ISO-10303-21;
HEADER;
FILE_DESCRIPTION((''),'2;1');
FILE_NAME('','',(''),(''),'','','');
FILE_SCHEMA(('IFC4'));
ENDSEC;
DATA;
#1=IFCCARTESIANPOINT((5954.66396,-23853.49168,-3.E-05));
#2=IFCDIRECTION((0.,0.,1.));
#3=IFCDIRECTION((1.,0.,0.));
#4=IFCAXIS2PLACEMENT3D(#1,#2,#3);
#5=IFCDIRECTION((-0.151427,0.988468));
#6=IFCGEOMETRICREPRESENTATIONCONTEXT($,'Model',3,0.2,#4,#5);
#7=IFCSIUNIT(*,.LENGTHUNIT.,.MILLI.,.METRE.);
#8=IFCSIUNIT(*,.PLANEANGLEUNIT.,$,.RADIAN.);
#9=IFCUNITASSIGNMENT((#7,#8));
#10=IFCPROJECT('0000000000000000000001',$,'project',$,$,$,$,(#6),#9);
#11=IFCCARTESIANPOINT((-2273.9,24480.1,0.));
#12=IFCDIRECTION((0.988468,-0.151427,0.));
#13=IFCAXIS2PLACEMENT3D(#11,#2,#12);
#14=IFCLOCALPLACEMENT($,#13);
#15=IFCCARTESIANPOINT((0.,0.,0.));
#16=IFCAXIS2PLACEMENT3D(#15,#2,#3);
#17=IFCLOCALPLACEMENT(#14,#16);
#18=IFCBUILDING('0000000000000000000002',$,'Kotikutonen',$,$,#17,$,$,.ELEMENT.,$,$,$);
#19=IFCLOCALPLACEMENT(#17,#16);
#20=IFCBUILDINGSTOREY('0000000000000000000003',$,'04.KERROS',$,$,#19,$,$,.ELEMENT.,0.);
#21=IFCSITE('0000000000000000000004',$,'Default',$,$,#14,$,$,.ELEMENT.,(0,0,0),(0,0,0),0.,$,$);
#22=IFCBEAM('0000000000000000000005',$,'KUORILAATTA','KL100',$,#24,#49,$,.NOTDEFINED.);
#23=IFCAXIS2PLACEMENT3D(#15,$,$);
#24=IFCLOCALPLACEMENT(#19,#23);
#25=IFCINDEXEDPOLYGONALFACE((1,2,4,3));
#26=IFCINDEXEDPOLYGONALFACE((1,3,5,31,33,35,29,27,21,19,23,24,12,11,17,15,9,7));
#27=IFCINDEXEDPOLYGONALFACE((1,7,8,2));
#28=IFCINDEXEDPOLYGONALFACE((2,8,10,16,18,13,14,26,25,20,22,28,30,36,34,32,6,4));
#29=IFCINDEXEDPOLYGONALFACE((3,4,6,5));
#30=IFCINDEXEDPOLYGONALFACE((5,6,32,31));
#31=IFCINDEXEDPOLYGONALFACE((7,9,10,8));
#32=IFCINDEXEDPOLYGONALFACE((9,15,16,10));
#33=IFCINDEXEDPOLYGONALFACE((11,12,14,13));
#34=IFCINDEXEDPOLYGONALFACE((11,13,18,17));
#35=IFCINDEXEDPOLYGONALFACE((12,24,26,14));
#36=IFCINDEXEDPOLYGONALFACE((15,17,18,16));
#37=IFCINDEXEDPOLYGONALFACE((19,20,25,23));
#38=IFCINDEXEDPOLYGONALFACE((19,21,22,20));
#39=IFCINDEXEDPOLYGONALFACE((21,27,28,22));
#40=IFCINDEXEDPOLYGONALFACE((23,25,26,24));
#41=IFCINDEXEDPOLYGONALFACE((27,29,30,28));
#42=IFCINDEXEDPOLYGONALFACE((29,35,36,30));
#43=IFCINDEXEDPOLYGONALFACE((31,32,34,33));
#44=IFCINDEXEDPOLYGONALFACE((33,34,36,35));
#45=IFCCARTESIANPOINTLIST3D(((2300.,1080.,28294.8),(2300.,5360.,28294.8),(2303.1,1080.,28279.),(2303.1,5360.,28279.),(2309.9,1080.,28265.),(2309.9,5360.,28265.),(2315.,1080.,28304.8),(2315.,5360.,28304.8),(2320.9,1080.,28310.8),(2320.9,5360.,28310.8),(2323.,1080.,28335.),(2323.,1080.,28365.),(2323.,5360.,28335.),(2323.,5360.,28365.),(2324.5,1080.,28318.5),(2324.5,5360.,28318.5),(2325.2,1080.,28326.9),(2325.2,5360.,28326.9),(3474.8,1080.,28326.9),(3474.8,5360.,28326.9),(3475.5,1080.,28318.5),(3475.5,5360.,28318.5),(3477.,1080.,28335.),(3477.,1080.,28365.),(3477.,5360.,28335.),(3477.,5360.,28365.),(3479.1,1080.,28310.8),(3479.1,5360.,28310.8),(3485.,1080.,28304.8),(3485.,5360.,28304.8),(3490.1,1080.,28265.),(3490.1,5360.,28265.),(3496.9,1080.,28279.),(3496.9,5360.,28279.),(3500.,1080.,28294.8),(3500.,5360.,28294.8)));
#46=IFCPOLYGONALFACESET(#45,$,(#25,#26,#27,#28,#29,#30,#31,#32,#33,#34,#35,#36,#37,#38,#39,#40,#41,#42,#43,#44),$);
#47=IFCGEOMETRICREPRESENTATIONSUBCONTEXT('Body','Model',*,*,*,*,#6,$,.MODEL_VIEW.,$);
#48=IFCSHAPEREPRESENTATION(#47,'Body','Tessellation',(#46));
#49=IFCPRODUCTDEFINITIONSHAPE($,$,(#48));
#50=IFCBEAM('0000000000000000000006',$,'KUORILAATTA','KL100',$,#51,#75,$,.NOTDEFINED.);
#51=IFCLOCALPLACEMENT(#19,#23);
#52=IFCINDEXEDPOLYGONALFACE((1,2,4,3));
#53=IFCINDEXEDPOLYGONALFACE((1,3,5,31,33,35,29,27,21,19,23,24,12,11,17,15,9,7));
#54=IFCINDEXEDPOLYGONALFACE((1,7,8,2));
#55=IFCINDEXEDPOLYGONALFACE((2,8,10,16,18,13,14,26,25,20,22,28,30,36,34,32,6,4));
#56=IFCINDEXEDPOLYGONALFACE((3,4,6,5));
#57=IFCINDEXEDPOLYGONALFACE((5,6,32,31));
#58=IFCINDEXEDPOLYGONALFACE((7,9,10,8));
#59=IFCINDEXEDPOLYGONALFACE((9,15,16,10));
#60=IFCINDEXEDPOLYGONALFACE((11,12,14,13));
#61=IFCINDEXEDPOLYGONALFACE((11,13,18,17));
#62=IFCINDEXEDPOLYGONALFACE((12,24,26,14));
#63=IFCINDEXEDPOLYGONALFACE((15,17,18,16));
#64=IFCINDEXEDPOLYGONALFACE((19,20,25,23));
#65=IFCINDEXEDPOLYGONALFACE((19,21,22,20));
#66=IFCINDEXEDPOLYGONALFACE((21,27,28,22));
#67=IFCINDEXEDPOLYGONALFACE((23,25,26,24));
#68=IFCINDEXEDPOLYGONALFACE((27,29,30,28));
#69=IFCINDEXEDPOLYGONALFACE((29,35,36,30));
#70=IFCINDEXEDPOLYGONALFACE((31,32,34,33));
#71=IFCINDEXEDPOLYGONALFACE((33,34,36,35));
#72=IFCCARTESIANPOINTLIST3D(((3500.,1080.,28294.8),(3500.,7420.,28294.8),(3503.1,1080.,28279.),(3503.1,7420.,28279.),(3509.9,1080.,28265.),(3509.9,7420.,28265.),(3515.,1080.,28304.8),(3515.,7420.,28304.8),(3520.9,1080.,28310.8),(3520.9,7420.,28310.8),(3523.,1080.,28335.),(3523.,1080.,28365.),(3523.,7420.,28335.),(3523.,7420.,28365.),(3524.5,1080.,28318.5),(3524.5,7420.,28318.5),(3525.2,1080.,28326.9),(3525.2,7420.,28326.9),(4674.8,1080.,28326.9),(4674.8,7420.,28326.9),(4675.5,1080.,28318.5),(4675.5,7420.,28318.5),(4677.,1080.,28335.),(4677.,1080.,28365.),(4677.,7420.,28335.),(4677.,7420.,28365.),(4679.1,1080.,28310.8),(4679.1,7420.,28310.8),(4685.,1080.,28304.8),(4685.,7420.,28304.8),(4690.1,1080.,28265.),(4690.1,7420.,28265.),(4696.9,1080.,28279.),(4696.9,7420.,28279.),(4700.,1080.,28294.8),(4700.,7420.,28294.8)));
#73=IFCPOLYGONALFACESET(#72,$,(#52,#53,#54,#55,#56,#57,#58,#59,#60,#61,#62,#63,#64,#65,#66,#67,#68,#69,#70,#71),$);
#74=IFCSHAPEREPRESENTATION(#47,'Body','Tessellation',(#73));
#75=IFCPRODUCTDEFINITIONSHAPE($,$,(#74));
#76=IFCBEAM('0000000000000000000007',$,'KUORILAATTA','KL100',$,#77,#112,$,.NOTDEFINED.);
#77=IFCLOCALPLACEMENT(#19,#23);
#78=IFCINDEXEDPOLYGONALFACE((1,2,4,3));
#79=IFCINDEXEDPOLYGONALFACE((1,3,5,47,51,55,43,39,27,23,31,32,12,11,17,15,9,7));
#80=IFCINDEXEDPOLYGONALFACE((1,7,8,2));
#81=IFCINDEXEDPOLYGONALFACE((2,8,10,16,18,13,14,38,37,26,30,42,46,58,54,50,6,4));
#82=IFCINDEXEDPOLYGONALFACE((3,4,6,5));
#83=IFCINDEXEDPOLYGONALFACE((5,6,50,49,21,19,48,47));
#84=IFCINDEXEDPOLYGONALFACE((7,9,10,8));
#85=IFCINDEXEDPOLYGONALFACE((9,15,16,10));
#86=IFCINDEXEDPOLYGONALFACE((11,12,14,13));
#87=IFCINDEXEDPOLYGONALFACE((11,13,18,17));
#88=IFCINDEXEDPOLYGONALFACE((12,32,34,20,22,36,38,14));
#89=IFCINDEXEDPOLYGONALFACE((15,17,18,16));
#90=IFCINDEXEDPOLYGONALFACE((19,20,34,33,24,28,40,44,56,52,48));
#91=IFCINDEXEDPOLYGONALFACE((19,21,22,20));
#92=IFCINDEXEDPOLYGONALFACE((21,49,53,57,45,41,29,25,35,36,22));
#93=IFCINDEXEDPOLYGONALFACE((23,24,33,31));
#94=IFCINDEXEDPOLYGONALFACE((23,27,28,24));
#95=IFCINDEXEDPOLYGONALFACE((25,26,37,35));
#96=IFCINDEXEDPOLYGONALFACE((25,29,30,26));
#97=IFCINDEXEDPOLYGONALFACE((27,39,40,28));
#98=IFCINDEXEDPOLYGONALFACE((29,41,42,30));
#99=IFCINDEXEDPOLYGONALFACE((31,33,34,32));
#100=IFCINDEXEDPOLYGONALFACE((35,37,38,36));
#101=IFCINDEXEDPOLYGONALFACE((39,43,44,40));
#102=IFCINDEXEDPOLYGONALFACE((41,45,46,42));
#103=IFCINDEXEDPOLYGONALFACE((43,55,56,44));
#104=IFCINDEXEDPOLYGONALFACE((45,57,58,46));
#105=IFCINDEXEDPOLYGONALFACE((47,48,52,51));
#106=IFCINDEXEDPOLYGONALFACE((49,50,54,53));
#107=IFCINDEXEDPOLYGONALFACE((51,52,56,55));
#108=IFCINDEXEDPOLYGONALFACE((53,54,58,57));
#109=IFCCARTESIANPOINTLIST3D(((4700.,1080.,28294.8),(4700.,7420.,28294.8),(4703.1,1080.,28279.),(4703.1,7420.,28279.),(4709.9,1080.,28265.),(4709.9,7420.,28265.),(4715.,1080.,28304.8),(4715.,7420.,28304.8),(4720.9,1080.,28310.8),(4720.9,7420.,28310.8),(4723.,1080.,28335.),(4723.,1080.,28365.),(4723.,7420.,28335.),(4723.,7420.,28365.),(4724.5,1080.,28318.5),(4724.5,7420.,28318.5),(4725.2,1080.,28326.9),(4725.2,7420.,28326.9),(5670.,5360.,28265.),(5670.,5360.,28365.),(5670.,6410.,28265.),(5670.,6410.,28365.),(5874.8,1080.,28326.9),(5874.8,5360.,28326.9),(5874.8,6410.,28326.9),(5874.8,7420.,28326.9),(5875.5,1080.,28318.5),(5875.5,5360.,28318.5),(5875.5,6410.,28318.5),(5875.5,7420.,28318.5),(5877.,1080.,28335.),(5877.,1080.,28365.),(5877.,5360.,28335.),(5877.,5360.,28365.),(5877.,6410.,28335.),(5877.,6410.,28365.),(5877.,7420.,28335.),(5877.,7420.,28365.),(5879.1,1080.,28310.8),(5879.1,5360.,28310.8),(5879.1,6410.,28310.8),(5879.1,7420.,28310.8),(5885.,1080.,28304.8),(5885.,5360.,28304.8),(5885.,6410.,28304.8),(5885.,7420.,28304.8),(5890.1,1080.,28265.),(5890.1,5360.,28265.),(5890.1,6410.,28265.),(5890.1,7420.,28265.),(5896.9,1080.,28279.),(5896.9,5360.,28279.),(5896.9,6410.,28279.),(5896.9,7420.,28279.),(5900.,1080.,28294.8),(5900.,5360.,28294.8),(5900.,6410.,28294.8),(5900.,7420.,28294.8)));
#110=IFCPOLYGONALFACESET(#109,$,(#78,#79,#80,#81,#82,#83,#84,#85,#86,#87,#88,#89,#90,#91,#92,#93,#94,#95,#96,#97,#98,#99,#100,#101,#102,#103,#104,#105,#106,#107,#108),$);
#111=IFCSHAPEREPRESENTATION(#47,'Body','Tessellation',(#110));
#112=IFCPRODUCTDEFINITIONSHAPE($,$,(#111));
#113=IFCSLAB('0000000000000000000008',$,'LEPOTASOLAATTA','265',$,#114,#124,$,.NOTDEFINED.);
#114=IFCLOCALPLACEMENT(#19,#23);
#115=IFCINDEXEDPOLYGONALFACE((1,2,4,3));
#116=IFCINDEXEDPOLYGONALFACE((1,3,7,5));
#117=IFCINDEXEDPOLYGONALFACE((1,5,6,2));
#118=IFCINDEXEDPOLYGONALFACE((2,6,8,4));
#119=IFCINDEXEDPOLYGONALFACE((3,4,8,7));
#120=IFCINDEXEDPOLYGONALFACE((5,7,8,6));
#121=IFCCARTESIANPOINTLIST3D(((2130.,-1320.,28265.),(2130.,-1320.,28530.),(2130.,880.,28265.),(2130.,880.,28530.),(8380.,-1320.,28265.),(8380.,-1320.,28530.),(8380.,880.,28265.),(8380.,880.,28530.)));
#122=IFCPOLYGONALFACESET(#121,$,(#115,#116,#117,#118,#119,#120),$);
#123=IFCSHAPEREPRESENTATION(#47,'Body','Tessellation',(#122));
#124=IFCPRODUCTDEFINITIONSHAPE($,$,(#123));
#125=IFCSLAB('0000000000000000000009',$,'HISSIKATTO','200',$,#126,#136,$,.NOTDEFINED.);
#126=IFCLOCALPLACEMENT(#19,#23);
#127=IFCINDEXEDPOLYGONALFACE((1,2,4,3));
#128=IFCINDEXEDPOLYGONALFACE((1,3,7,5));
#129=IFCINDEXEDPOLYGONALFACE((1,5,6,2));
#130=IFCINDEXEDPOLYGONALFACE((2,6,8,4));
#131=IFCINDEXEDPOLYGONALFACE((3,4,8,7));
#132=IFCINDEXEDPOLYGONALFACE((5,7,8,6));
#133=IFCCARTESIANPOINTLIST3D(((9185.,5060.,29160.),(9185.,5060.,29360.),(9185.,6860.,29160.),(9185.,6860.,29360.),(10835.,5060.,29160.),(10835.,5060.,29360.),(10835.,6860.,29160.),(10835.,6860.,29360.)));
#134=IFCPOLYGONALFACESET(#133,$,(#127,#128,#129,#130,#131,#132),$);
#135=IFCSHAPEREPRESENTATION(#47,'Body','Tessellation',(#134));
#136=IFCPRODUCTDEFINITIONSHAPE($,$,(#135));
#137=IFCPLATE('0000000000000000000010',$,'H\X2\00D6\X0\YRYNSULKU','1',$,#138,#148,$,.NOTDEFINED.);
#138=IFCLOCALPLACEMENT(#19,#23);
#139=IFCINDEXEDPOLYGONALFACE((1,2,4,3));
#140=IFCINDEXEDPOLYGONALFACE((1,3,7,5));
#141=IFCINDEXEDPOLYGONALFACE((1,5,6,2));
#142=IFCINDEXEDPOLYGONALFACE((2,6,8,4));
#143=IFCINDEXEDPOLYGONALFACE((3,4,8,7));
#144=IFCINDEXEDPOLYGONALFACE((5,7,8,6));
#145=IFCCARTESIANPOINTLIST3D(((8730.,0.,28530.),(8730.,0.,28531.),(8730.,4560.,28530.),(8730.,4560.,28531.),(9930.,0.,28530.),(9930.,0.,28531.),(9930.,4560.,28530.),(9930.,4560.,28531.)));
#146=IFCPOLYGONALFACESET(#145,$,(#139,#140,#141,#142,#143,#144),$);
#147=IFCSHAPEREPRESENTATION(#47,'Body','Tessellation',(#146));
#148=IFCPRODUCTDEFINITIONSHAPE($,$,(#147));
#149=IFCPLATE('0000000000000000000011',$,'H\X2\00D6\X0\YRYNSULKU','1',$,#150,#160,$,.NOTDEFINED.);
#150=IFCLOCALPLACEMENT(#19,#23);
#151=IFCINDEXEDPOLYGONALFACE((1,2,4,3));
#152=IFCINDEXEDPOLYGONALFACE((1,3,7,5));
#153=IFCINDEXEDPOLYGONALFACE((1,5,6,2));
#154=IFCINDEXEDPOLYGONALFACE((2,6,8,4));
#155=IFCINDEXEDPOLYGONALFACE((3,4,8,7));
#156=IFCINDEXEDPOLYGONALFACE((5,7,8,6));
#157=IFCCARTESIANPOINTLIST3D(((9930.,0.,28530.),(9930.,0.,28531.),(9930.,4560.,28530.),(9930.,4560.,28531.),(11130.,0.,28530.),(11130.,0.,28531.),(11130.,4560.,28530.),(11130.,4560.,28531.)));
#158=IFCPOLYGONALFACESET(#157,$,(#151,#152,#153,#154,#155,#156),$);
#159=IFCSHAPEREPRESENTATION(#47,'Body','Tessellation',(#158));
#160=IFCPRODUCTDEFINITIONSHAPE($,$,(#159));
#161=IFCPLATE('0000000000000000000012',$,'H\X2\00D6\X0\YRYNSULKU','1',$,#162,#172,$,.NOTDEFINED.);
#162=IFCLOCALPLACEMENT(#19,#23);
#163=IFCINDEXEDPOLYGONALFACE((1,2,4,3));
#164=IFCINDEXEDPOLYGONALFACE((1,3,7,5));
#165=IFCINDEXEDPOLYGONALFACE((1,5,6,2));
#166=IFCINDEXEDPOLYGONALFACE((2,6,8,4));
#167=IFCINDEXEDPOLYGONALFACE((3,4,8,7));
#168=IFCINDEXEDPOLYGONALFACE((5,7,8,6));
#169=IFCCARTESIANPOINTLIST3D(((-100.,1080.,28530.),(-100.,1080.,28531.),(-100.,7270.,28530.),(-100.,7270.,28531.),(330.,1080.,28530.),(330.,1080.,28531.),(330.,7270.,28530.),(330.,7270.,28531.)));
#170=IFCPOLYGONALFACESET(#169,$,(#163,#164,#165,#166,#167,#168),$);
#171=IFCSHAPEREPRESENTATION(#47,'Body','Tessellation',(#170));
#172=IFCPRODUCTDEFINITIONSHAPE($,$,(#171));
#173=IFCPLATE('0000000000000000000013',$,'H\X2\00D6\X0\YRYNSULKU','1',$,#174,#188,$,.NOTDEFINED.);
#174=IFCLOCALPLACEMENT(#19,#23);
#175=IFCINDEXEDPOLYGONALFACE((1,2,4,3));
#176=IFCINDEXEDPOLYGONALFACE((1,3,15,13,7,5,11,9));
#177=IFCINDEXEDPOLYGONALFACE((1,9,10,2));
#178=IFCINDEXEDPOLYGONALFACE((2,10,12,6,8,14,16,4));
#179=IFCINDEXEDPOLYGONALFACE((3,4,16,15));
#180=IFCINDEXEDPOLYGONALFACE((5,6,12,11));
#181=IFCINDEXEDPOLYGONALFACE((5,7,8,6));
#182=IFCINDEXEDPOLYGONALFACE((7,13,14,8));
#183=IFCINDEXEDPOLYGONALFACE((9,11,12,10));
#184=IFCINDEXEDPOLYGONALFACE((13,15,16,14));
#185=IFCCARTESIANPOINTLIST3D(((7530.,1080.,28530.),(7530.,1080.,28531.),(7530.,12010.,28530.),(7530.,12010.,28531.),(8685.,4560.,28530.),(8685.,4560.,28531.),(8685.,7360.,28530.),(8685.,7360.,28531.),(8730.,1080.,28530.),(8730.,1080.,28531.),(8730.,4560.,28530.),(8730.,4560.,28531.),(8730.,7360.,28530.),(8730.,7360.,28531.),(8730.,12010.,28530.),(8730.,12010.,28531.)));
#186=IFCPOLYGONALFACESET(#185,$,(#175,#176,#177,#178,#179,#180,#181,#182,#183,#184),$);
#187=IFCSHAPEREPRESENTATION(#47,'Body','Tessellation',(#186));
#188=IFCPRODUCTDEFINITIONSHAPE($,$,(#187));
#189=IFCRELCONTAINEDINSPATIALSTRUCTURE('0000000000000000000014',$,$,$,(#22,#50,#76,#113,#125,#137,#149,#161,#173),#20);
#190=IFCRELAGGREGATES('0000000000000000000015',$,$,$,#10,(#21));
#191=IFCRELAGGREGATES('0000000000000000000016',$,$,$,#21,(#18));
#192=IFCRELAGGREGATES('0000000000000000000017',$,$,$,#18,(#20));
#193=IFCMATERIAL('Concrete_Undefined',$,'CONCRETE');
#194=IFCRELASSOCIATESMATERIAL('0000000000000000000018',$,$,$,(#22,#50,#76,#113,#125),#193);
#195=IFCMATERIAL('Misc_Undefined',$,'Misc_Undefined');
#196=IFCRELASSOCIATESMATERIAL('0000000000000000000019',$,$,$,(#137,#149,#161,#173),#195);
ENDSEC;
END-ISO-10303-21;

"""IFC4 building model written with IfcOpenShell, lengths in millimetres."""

from ifc_helpers import new_model, si_unit, direction, frame, origin_with_axes, place, context, subcontext, project, spatial, line, indexed_curve, outline, extrude, material, element, save


model = new_model("IFC4")

# Units and contexts
model_context = context("Model", 3, precision=0.2, world=frame((5954.66396, -23853.49168, -3e-05), z_axis=(0.0, 0.0, 1.0), x_axis=(1.0, 0.0, 0.0)), true_north=direction((-0.151427, 0.988468)))
body_context = subcontext(model_context, "Body", "Model", "MODEL_VIEW")
ifc_project = project(units=[si_unit("LENGTHUNIT", "METRE", prefix="MILLI"), si_unit("PLANEANGLEUNIT", "RADIAN")], contexts=[model_context])

# Site, building, storey
site_placement = place(None, frame((-2273.9, 24480.1, 0.0), z_axis=(0.0, 0.0, 1.0), x_axis=(0.988468, -0.151427, 0.0)))
site = spatial("IfcSite", under=ifc_project, at=site_placement, Name="Default", CompositionType="ELEMENT", RefLatitude=(0, 0, 0), RefLongitude=(0, 0, 0), RefElevation=0.0)
building_placement = place(site_placement, origin_with_axes())
building = spatial("IfcBuilding", under=site, at=building_placement, Name="Kotikutonen", CompositionType="ELEMENT")
storey_placement = place(building_placement, origin_with_axes())
storey = spatial("IfcBuildingStorey", under=building, at=storey_placement, Name="04.KERROS", CompositionType="ELEMENT", Elevation=0.0)

# Shared definitions
ifc_material_1 = material(Name="Concrete_Undefined", Category="CONCRETE")

# Beams
beam_1_placement = place(storey_placement, frame((2900.0, 5360.0, 28315.0), z_axis=(-1.0, 0.0, 0.0), x_axis=(0.0, -1.0, 0.0)))
element("IfcBeam", 1, at=beam_1_placement, inside=storey, material=ifc_material_1, Name="KUORILAATTA", Description="KL100", PredefinedType="NOTDEFINED", context=body_context, shape_type="SolidModel", body=[
    extrude(outline(indexed_curve([(-596.9, -36.0), (-590.1, -50.0), (590.1, -50.0), (596.9, -36.0), (600.0, -20.2), (585.0, -10.2), (579.1, -4.2), (575.5, 3.5), (574.8, 11.9), (577.0, 20.0), (577.0, 50.0), (-577.0, 50.0), (-577.0, 20.0), (-574.8, 11.9), (-575.5, 3.5), (-579.1, -4.2), (-585.0, -10.2), (-600.0, -20.2)], segments=[line(1, 2, 3, 4, 5, 6, 7, 8, 9, 10, 11, 12, 13, 14, 15, 16, 17, 18, 1)])), frame((0.0, 0.0, 0.0), z_axis=(-1.0, 0.0, 0.0), x_axis=(0.0, 0.0, 1.0)), (0.0, 0.0, -1.0), 4280.0),
])
beam_2_placement = place(storey_placement, frame((4100.0, 7420.0, 28315.0), z_axis=(-1.0, 0.0, 0.0), x_axis=(0.0, -1.0, 0.0)))
element("IfcBeam", 2, at=beam_2_placement, inside=storey, material=ifc_material_1, Name="KUORILAATTA", Description="KL100", PredefinedType="NOTDEFINED", context=body_context, shape_type="SolidModel", body=[
    extrude(outline(indexed_curve([(-596.9, -36.0), (-590.1, -50.0), (590.1, -50.0), (596.9, -36.0), (600.0, -20.2), (585.0, -10.2), (579.1, -4.2), (575.5, 3.5), (574.8, 11.9), (577.0, 20.0), (577.0, 50.0), (-577.0, 50.0), (-577.0, 20.0), (-574.8, 11.9), (-575.5, 3.5), (-579.1, -4.2), (-585.0, -10.2), (-600.0, -20.2)], segments=[line(1, 2, 3, 4, 5, 6, 7, 8, 9, 10, 11, 12, 13, 14, 15, 16, 17, 18, 1)])), frame((0.0, 0.0, 0.0), z_axis=(-1.0, 0.0, 0.0), x_axis=(0.0, 0.0, 1.0)), (0.0, 0.0, -1.0), 6340.0),
])

# Beam, voiding feature
beam_3_placement = place(storey_placement, frame((5300.0, 7420.0, 28315.0), z_axis=(-1.0, 0.0, 0.0), x_axis=(0.0, -1.0, 0.0)))
beam_3 = element("IfcBeam", 3, at=beam_3_placement, inside=storey, material=ifc_material_1, Name="KUORILAATTA", Description="KL100", PredefinedType="NOTDEFINED", context=body_context, shape_type="SolidModel", body=[
    extrude(outline(indexed_curve([(-596.9, -36.0), (-590.1, -50.0), (590.1, -50.0), (596.9, -36.0), (600.0, -20.2), (585.0, -10.2), (579.1, -4.2), (575.5, 3.5), (574.8, 11.9), (577.0, 20.0), (577.0, 50.0), (-577.0, 50.0), (-577.0, 20.0), (-574.8, 11.9), (-575.5, 3.5), (-579.1, -4.2), (-585.0, -10.2), (-600.0, -20.2)], segments=[line(1, 2, 3, 4, 5, 6, 7, 8, 9, 10, 11, 12, 13, 14, 15, 16, 17, 18, 1)])), frame((0.0, 0.0, 0.0), z_axis=(-1.0, 0.0, 0.0), x_axis=(0.0, 0.0, 1.0)), (0.0, 0.0, -1.0), 6340.0),
])
voiding_feature_1_placement = place(beam_3_placement, frame((2060.0, 0.0, -370.0), z_axis=(0.0, 1.0, 0.0), x_axis=(0.0, 0.0, -1.0)))
element("IfcVoidingFeature", 4, at=voiding_feature_1_placement, cuts=beam_3, Name="Opening", PredefinedType="HOLE", context=body_context, shape_type="SolidModel", body=[
    extrude(outline(indexed_curve([(0.0, 0.0), (480.0, 0.0), (480.0, 1050.0), (0.0, 1050.0)], segments=[line(1, 2, 3, 4, 1)])), frame((0.0, 0.0, 125.0), z_axis=(0.0, 0.0, 1.0), x_axis=(1.0, 0.0, 0.0)), (0.0, 0.0, -1.0), 250.0),
])

# Slabs
slab_1_placement = place(storey_placement, frame((2130.0, 880.0, 28397.5), z_axis=(0.0, 0.0, 1.0), x_axis=(0.0, -1.0, 0.0)))
element("IfcSlab", 5, at=slab_1_placement, inside=storey, material=ifc_material_1, Name="LEPOTASOLAATTA", Description="265", PredefinedType="NOTDEFINED", context=body_context, shape_type="SolidModel", body=[
    extrude(outline(indexed_curve([(0.0, 0.0), (2200.0, 0.0), (2200.0, 6250.0), (0.0, 6250.0)], segments=[line(1, 2, 3, 4, 1)])), frame((0.0, 0.0, 132.5), z_axis=(0.0, 0.0, 1.0), x_axis=(1.0, 0.0, 0.0)), (0.0, 0.0, -1.0), 265.0),
])
slab_2_placement = place(storey_placement, frame((9185.0, 5060.0, 29260.0), z_axis=(0.0, 0.0, 1.0), x_axis=(1.0, 0.0, 0.0)))
element("IfcSlab", 6, at=slab_2_placement, inside=storey, material=ifc_material_1, Name="HISSIKATTO", Description="200", PredefinedType="NOTDEFINED", context=body_context, shape_type="SolidModel", body=[
    extrude(outline(indexed_curve([(0.0, 0.0), (1650.0, 0.0), (1650.0, 1800.0), (0.0, 1800.0)], segments=[line(1, 2, 3, 4, 1)])), frame((0.0, 0.0, 100.0), z_axis=(0.0, 0.0, 1.0), x_axis=(1.0, 0.0, 0.0)), (0.0, 0.0, -1.0), 200.0),
])

# Plates
ifc_material_2 = material(Name="Misc_Undefined", Category="Misc_Undefined")
for number, where, z_axis, x_axis, name in (
    (7, (8730.0, 0.0, 28530.5), (0.0, 0.0, 1.0), (1.0, 0.0, 0.0), "HÖYRYNSULKU"),
    (8, (9930.0, 0.0, 28530.5), (0.0, 0.0, 1.0), (1.0, 0.0, 0.0), "HÖYRYNSULKU"),
):
    element("IfcPlate", number, at=place(storey_placement, frame(where, z_axis=z_axis, x_axis=x_axis)), inside=storey, material=ifc_material_2, Name=name, Description="1", PredefinedType="NOTDEFINED", context=body_context, shape_type="SolidModel", body=[
        extrude(outline(indexed_curve([(0.0, 0.0), (1200.0, 0.0), (1200.0, 4560.0), (0.0, 4560.0)], segments=[line(1, 2, 3, 4, 1)])), frame((0.0, 0.0, 0.5), z_axis=(0.0, 0.0, 1.0), x_axis=(1.0, 0.0, 0.0)), (0.0, 0.0, -1.0), 1.0),
    ])
plate_1_placement = place(storey_placement, frame((-100.0, 7270.0, 28530.5), z_axis=(0.0, 0.0, 1.0), x_axis=(0.0, -1.0, 0.0)))
element("IfcPlate", 9, at=plate_1_placement, inside=storey, material=ifc_material_2, Name="HÖYRYNSULKU", Description="1", PredefinedType="NOTDEFINED", context=body_context, shape_type="SolidModel", body=[
    extrude(outline(indexed_curve([(0.0, 0.0), (6190.0, 0.0), (6190.0, 430.0), (0.0, 430.0)], segments=[line(1, 2, 3, 4, 1)])), frame((0.0, 0.0, 0.5), z_axis=(0.0, 0.0, 1.0), x_axis=(1.0, 0.0, 0.0)), (0.0, 0.0, -1.0), 1.0),
])
plate_2_placement = place(storey_placement, frame((8730.0, 1080.0, 28530.5), z_axis=(0.0, 0.0, 1.0), x_axis=(0.0, 1.0, 0.0)))
element("IfcPlate", 10, at=plate_2_placement, inside=storey, material=ifc_material_2, Name="HÖYRYNSULKU", Description="1", PredefinedType="NOTDEFINED", context=body_context, shape_type="SolidModel", body=[
    extrude(outline(indexed_curve([(0.0, 0.0), (3480.0, 0.0), (3480.0, 45.0), (6280.0, 45.0), (6280.0, 0.0), (10930.0, 0.0), (10930.0, 1200.0), (0.0, 1200.0)], segments=[line(1, 2, 3, 4, 5, 6, 7, 8, 1)])), frame((0.0, 0.0, 0.5), z_axis=(0.0, 0.0, 1.0), x_axis=(1.0, 0.0, 0.0)), (0.0, 0.0, -1.0), 1.0),
])

save(model, "model.ifc")
